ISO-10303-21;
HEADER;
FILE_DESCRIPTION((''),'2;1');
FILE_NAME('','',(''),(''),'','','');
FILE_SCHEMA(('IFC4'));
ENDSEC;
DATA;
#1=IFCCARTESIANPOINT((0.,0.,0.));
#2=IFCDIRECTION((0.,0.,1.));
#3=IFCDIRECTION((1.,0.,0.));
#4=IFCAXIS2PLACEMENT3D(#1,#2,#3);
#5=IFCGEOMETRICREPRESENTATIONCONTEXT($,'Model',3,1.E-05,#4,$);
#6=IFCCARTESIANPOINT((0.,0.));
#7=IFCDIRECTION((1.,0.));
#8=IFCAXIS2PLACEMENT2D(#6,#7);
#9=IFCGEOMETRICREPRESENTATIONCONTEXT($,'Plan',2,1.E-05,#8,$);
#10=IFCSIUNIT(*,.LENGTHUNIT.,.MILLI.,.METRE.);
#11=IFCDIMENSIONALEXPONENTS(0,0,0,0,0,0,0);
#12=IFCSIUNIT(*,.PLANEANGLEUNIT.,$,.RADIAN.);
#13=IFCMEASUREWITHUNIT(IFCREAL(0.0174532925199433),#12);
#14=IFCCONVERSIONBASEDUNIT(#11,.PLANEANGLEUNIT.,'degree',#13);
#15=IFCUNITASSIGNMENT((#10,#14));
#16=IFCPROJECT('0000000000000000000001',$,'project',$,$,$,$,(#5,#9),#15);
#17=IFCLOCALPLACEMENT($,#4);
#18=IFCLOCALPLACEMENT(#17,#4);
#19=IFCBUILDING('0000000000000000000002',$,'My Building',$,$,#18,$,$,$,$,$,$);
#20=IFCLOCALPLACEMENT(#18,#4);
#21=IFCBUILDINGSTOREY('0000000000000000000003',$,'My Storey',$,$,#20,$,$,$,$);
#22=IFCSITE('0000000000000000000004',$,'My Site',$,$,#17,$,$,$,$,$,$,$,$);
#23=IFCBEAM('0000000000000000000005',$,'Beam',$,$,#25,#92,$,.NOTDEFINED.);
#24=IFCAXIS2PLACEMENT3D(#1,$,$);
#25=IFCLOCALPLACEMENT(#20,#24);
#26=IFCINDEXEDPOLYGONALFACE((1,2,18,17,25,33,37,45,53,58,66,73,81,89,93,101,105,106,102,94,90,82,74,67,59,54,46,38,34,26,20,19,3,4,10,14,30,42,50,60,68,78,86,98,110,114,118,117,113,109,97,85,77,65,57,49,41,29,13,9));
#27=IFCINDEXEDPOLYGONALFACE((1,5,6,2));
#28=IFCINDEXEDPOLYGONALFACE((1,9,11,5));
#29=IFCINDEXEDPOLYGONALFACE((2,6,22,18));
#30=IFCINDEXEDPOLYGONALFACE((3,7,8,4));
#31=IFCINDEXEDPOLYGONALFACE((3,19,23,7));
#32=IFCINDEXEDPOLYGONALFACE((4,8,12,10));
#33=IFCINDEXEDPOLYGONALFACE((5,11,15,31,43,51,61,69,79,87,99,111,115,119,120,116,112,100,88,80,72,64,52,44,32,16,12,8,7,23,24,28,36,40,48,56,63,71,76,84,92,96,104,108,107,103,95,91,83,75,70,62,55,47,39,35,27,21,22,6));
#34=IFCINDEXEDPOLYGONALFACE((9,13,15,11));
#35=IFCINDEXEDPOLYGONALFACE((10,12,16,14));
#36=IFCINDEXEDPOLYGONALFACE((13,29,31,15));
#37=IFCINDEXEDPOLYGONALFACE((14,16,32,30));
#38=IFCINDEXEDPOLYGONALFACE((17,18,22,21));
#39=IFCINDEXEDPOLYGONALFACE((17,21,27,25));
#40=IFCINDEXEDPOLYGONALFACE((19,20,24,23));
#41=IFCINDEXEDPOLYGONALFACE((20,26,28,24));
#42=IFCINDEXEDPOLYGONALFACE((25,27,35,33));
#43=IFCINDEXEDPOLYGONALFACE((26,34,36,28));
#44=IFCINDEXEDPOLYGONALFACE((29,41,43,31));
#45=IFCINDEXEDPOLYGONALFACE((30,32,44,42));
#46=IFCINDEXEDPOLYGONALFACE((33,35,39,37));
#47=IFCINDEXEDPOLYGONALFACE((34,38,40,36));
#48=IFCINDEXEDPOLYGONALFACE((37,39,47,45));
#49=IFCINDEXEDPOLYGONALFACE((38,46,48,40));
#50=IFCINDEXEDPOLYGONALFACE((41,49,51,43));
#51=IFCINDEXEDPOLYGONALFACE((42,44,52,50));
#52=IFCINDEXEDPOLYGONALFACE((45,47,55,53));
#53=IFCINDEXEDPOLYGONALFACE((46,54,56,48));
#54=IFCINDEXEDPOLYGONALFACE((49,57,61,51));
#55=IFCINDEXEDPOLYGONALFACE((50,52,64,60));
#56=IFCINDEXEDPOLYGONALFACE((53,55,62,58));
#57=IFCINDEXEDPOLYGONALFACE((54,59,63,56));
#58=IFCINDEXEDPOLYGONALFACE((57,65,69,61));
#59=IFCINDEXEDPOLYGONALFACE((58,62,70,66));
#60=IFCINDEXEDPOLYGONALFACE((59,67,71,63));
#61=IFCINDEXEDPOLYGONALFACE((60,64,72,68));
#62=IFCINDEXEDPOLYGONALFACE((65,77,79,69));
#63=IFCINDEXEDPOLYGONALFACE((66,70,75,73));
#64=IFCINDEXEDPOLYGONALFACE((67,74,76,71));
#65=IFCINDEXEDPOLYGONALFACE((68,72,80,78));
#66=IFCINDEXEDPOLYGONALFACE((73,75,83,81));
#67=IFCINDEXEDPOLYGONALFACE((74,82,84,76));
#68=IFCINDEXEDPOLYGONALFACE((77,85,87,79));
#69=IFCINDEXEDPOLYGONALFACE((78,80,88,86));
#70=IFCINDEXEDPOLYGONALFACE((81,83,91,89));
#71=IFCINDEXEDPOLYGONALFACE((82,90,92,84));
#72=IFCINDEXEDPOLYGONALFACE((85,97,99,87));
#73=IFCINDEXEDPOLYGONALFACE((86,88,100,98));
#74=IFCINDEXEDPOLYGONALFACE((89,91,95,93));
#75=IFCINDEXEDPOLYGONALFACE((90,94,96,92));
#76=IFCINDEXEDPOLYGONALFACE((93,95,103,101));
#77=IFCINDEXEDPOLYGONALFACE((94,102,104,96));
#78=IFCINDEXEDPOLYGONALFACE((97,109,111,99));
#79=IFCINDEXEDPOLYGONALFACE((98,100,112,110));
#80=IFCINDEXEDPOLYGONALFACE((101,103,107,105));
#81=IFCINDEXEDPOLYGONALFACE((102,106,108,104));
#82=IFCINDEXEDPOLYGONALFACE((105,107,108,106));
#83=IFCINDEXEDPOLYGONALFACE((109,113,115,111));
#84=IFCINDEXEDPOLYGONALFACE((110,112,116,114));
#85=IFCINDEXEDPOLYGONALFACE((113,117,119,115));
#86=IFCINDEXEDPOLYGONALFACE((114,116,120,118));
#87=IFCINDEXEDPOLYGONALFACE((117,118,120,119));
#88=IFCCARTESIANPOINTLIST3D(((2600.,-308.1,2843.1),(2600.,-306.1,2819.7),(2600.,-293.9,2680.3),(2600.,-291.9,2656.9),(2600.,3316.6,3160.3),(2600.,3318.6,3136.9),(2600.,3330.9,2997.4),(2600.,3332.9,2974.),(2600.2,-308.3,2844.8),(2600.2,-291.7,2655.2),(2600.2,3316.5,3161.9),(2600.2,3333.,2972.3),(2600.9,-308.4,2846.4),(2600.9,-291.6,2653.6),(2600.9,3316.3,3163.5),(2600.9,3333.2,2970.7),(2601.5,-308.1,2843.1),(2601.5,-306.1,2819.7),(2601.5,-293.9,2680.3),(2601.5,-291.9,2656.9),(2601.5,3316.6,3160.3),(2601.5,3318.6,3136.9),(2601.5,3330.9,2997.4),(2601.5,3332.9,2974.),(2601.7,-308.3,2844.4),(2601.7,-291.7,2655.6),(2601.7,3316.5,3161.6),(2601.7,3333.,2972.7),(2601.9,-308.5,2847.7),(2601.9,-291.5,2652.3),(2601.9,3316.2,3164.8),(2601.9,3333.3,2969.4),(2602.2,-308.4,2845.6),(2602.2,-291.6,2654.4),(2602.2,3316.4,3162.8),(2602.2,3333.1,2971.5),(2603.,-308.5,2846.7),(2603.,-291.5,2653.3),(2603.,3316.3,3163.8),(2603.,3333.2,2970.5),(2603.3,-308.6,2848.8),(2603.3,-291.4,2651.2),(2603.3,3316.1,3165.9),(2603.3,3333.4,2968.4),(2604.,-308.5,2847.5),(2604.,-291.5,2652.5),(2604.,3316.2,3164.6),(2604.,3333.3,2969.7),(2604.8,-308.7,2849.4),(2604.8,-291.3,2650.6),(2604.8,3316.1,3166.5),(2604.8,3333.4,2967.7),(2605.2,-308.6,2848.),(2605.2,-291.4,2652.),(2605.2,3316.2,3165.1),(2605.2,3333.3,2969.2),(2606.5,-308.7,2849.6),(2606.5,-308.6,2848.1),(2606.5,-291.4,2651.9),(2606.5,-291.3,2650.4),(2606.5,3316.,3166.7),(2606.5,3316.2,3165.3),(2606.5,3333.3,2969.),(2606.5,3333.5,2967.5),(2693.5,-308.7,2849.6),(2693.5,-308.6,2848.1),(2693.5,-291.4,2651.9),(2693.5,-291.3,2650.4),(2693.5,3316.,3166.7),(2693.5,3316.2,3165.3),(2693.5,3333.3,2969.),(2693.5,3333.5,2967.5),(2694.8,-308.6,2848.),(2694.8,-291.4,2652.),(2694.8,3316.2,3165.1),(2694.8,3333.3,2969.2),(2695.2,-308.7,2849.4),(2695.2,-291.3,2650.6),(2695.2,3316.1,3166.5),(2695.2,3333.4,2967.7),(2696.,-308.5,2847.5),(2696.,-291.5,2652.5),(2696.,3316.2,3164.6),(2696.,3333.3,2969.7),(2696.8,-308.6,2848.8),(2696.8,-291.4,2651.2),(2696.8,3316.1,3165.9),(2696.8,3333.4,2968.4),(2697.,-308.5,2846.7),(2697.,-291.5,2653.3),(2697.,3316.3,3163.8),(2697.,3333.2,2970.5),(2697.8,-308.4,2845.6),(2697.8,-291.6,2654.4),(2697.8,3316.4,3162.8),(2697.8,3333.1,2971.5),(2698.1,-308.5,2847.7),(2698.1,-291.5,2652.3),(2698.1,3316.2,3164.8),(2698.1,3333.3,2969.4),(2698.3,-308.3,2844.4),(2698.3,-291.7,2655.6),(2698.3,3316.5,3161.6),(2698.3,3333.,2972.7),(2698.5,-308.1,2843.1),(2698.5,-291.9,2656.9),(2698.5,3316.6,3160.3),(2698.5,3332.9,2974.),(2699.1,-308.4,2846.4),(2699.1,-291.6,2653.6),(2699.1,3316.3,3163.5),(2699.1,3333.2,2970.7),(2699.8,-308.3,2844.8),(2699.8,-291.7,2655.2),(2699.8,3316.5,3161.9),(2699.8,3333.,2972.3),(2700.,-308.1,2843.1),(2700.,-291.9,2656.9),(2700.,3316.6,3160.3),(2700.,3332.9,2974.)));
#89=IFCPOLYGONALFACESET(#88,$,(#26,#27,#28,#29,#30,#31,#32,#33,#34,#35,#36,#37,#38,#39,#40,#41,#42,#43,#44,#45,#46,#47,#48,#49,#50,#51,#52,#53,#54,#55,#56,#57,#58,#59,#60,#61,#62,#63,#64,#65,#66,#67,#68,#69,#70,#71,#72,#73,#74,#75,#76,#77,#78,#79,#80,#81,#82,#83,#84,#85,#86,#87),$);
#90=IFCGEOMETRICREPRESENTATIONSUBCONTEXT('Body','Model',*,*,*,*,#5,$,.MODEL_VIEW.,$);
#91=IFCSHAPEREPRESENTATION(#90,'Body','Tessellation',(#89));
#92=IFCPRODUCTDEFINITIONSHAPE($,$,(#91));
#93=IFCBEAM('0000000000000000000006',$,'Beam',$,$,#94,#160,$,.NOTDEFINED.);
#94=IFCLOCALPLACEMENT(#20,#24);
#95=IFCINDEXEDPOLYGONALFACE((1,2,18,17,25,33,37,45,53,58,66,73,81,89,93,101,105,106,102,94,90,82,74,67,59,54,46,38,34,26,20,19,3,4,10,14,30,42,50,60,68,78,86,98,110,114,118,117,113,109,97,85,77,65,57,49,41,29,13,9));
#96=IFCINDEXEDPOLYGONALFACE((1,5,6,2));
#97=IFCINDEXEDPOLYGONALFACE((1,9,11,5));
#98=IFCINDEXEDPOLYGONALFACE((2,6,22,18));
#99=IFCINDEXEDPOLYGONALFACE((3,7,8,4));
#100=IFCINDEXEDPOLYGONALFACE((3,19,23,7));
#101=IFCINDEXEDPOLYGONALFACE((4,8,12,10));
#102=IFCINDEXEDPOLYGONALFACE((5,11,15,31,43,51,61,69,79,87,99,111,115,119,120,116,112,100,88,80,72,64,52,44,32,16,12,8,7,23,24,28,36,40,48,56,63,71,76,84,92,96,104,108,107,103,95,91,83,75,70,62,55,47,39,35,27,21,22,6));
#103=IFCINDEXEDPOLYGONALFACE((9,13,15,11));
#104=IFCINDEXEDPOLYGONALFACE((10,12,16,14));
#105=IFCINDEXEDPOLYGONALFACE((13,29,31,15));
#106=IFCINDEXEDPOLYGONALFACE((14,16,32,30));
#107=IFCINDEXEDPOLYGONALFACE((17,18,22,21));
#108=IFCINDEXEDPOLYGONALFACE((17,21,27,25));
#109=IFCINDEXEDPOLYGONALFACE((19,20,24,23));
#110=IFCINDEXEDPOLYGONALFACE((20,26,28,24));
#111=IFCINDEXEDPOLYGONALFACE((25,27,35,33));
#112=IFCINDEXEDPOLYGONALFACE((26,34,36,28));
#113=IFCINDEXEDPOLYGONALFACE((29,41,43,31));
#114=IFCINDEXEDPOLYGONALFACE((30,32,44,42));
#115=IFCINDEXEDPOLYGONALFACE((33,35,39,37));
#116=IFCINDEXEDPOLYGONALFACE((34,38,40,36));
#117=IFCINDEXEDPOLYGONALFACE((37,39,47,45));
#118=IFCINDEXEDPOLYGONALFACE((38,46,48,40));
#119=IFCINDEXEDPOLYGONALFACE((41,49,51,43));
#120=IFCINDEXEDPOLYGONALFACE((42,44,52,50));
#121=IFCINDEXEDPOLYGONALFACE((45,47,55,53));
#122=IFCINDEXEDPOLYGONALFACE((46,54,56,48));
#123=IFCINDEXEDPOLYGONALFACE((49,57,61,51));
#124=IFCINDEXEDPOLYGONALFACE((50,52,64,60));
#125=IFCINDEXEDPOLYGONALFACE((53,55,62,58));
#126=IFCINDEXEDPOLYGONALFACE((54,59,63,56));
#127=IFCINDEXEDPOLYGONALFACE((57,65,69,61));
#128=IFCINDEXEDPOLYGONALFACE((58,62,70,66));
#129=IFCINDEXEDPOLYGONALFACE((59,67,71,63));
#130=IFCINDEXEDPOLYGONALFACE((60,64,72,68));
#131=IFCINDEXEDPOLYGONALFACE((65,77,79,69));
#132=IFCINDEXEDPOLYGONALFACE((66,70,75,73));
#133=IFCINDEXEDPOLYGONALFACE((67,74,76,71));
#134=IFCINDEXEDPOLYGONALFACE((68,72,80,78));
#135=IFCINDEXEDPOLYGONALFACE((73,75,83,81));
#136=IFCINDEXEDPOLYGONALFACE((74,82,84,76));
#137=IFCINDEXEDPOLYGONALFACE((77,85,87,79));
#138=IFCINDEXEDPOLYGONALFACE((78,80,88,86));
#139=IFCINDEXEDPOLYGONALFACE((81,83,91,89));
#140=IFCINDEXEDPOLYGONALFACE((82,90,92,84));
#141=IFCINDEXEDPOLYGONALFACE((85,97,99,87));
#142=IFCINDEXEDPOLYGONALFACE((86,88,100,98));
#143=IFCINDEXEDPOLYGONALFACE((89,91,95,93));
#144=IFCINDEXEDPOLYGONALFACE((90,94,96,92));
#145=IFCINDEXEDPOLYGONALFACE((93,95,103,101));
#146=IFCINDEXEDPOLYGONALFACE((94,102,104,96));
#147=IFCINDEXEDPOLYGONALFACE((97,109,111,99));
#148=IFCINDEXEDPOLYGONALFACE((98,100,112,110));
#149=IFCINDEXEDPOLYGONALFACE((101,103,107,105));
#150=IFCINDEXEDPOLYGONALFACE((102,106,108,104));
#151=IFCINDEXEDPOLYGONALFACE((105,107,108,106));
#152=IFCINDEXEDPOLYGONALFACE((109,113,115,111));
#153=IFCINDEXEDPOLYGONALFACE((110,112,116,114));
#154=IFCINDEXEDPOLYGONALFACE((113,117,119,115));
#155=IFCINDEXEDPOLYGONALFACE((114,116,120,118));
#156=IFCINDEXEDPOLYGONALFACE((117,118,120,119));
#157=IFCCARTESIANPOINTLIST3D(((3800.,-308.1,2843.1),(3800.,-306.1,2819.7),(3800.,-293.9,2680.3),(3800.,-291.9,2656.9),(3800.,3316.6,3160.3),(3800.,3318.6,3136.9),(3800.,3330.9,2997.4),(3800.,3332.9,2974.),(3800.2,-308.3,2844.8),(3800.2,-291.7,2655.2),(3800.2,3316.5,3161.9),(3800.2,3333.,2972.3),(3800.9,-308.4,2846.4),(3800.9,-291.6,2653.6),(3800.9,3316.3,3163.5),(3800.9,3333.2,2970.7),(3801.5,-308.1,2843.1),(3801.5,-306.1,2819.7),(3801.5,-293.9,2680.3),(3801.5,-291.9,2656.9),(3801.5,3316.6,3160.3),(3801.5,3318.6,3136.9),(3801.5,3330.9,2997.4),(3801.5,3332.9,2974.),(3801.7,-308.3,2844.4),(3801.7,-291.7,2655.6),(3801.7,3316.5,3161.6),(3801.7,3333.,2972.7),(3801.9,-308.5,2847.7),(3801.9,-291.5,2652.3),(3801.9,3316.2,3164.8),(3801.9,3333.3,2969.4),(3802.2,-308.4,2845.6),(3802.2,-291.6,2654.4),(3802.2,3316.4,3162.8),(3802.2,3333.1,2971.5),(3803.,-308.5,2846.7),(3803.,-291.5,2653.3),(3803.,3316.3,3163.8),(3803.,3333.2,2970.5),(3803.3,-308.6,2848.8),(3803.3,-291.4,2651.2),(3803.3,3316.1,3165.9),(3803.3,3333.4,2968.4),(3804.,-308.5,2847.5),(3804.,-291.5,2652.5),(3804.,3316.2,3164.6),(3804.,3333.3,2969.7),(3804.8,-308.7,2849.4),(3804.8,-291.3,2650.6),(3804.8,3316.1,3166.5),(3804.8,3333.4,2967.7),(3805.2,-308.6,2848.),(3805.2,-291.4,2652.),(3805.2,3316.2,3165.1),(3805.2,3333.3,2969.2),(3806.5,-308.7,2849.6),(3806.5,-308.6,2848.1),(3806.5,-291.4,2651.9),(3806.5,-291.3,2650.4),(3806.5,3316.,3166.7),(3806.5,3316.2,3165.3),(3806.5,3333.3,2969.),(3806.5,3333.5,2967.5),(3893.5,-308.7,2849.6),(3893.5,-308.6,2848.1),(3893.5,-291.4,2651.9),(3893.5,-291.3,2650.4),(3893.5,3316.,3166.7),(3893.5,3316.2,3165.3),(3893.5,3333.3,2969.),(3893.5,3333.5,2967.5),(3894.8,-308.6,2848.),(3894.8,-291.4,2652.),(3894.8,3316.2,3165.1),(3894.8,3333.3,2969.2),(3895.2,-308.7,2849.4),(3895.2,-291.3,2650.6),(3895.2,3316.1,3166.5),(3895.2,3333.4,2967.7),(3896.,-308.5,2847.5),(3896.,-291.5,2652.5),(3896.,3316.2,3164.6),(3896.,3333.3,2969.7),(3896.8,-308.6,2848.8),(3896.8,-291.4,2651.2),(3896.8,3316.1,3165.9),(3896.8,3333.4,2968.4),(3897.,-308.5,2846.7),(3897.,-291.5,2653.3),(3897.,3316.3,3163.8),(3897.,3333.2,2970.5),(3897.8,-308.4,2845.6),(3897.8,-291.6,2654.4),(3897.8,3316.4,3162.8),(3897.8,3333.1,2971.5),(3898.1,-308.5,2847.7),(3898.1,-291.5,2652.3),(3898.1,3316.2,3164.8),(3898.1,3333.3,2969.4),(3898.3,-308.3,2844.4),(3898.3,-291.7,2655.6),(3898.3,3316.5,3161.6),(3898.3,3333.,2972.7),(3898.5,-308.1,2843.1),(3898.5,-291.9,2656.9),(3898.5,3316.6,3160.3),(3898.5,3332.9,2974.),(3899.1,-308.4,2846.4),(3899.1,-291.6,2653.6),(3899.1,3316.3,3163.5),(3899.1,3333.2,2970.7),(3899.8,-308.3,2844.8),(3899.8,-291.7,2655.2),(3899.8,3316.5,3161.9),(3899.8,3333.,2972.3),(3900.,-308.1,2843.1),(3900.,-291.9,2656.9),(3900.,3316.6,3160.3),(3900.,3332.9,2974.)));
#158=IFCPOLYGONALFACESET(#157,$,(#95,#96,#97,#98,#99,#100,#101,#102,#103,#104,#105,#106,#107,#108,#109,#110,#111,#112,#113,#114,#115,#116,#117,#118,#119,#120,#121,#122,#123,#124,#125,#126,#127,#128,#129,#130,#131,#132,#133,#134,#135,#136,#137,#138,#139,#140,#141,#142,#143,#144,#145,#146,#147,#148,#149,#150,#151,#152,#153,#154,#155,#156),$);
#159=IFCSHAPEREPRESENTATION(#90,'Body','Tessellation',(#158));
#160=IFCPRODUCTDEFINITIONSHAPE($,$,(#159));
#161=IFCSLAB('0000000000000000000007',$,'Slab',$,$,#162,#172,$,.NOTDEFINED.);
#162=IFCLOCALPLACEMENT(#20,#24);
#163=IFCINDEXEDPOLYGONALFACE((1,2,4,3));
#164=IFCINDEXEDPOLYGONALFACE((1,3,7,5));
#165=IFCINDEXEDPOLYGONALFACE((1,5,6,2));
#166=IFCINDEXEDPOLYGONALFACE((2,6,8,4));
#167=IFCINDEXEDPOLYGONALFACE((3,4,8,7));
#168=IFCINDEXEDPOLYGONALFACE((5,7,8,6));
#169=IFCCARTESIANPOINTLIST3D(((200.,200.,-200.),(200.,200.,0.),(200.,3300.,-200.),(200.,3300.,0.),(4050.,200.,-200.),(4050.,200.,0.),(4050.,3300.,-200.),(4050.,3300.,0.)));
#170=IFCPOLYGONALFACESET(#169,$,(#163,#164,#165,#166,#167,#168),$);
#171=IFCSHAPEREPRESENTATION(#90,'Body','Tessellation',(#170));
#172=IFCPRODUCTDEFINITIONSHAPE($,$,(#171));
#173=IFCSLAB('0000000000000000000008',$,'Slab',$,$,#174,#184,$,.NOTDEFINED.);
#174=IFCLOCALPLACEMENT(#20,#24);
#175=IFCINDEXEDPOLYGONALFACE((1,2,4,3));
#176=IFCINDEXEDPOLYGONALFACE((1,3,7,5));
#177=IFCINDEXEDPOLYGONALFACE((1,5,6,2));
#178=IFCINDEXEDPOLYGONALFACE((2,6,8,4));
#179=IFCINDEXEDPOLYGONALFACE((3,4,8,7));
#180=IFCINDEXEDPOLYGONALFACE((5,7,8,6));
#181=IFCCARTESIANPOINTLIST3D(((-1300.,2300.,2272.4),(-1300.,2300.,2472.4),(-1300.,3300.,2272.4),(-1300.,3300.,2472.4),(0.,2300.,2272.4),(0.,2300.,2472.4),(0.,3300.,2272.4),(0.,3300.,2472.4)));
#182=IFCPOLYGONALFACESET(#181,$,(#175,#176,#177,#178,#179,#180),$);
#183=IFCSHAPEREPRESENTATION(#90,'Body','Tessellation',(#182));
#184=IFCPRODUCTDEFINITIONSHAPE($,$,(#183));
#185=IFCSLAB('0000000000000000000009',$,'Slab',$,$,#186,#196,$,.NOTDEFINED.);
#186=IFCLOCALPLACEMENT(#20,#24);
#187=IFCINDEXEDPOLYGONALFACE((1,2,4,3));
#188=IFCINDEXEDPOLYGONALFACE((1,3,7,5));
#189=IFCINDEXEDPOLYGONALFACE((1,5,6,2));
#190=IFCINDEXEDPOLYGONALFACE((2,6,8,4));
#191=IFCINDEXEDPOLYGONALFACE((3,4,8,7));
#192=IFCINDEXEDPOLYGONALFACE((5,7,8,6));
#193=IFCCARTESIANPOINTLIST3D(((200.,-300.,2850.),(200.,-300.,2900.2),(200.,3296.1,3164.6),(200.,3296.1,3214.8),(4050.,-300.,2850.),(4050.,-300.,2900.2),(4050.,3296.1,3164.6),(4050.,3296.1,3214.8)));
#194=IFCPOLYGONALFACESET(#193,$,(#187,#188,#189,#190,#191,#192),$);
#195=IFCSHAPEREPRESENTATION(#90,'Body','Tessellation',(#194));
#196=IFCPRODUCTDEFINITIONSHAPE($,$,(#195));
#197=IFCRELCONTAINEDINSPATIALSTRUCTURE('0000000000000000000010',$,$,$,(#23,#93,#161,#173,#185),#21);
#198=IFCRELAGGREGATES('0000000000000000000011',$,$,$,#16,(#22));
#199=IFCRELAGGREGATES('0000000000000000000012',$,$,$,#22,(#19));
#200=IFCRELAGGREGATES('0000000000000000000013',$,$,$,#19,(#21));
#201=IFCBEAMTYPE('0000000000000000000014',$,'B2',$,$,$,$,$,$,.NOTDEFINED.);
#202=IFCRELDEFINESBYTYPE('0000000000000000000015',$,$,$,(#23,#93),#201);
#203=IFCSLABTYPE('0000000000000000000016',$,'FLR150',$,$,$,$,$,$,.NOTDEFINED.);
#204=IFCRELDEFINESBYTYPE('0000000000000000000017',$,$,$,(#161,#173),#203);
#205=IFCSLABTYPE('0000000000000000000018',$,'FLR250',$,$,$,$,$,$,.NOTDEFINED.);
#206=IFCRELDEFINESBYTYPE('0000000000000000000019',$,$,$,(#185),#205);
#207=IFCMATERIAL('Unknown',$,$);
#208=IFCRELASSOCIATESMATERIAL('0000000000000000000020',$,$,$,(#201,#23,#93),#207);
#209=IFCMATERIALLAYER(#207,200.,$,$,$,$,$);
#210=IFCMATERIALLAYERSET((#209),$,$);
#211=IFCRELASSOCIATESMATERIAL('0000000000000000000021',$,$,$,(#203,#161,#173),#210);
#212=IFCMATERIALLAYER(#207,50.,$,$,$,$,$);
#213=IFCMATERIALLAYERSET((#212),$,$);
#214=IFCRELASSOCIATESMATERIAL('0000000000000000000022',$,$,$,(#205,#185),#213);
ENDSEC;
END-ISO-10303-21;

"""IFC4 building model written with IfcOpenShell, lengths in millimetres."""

from ifc_helpers import new_model, entity, si_unit, converted_unit, frame, origin_with_axes, origin_2d_with_axis, place, context, subcontext, project, spatial, line, indexed_curve, c_section, outline, extrude, material, layer, layer_set, layer_usage, material_profile, profile_set, profile_usage, type_object, element, save


model = new_model("IFC4")

# Units and contexts
model_context = context("Model", 3, precision=1e-05, world=origin_with_axes())
plan_context = context("Plan", 2, precision=1e-05, world=origin_2d_with_axis())
body_context = subcontext(model_context, "Body", "Model", "MODEL_VIEW")
ifc_project = project(units=[si_unit("LENGTHUNIT", "METRE", prefix="MILLI"), converted_unit("PLANEANGLEUNIT", "degree", entity("IfcReal", 0.0174532925199433), si_unit("PLANEANGLEUNIT", "RADIAN"), dimensions=[0, 0, 0, 0, 0, 0, 0])], contexts=[model_context, plan_context])

# Site, building, storey
site_placement = place(None, origin_with_axes())
site = spatial("IfcSite", under=ifc_project, at=site_placement, Name="My Site")
building_placement = place(site_placement, origin_with_axes())
building = spatial("IfcBuilding", under=site, at=building_placement, Name="My Building")
storey_placement = place(building_placement, origin_with_axes())
storey = spatial("IfcBuildingStorey", under=building, at=storey_placement, Name="My Storey")

# Shared definitions
ifc_material = material(Name="Unknown")

# Beams
ifc_material_profile_1 = material_profile(ifc_material, c_section(Depth=200.0, Width=100.0, WallThickness=1.5, Girth=30.0, InternalFilletRadius=5.0))
ifc_profile_set_1 = profile_set([ifc_material_profile_1])
beam_type_1 = type_object("IfcBeamType", Name="B2", PredefinedType="NOTDEFINED", material=ifc_profile_set_1)
ifc_profile_usage_1 = profile_usage(ifc_profile_set_1, cardinal=5)
beam_1_placement = place(storey_placement, frame((2650.0, -300.0, 2750.0), z_axis=(0.0, 0.996195, 0.087156), x_axis=(-1.0, 0.0, 0.0)))
element("IfcBeam", 1, at=beam_1_placement, inside=storey, type_object=beam_type_1, material=ifc_profile_usage_1, Name="Beam", PredefinedType="NOTDEFINED", context=body_context, shape_type="SweptSolid", body=[
    extrude(c_section(Depth=200.0, Width=100.0, WallThickness=1.5, Girth=30.0, InternalFilletRadius=5.0), origin_with_axes(), (0.0, 0.0, 1.0), 3638.6),
])
ifc_profile_usage_2 = profile_usage(ifc_profile_set_1, cardinal=5)
beam_2_placement = place(storey_placement, frame((3850.0, -300.0, 2750.0), z_axis=(0.0, 0.996195, 0.087156), x_axis=(-1.0, 0.0, 0.0)))
element("IfcBeam", 2, at=beam_2_placement, inside=storey, type_object=beam_type_1, material=ifc_profile_usage_2, Name="Beam", PredefinedType="NOTDEFINED", context=body_context, shape_type="SweptSolid", body=[
    extrude(c_section(Depth=200.0, Width=100.0, WallThickness=1.5, Girth=30.0, InternalFilletRadius=5.0), origin_with_axes(), (0.0, 0.0, 1.0), 3638.6),
])

# Slabs
ifc_layer_1 = layer(ifc_material, 200.0)
ifc_layer_set_1 = layer_set([ifc_layer_1])
ifc_layer_usage_1 = layer_usage(ifc_layer_set_1, "AXIS3", "POSITIVE", 0.0)
slab_type_1 = type_object("IfcSlabType", Name="FLR150", PredefinedType="NOTDEFINED", material=ifc_layer_set_1)
slab_1_placement = place(storey_placement, frame((200.0, 200.0, -200.0), z_axis=(0.0, 0.0, 1.0), x_axis=(1.0, 0.0, 0.0)))
element("IfcSlab", 3, at=slab_1_placement, inside=storey, type_object=slab_type_1, material=ifc_layer_usage_1, Name="Slab", PredefinedType="NOTDEFINED", context=body_context, shape_type="SweptSolid", body=[
    extrude(outline(indexed_curve([(0.0, 0.0), (3850.0, 0.0), (3850.0, 3100.0), (0.0, 3100.0)], segments=[line(3, 2), line(2, 1), line(1, 4), line(4, 3)], self_intersect=False)), None, (0.0, 0.0, 1.0), 200.0),
])
ifc_layer_usage_2 = layer_usage(ifc_layer_set_1, "AXIS3", "POSITIVE", 0.0)
slab_2_placement = place(storey_placement, frame((-1300.0, 2300.0, 2272.4), z_axis=(0.0, 0.0, 1.0), x_axis=(1.0, 0.0, 0.0)))
element("IfcSlab", 4, at=slab_2_placement, inside=storey, type_object=slab_type_1, material=ifc_layer_usage_2, Name="Slab", PredefinedType="NOTDEFINED", context=body_context, shape_type="SweptSolid", body=[
    extrude(outline(indexed_curve([(0.0, 0.0), (1300.0, 0.0), (1300.0, 1000.0), (0.0, 1000.0)], segments=[line(4, 1), line(1, 2), line(2, 3), line(3, 4)], self_intersect=False)), None, (0.0, 0.0, 1.0), 200.0),
])
ifc_layer_2 = layer(ifc_material, 50.0)
ifc_layer_set_2 = layer_set([ifc_layer_2])
ifc_layer_usage_3 = layer_usage(ifc_layer_set_2, "AXIS3", "POSITIVE", 0.0)
slab_type_2 = type_object("IfcSlabType", Name="FLR250", PredefinedType="NOTDEFINED", material=ifc_layer_set_2)
slab_3_placement = place(storey_placement, frame((200.0, -300.0, 2850.0), z_axis=(0.0, -0.087156, 0.996195), x_axis=(1.0, 0.0, 0.0)))
element("IfcSlab", 5, at=slab_3_placement, inside=storey, type_object=slab_type_2, material=ifc_layer_usage_3, Name="Slab", PredefinedType="NOTDEFINED", context=body_context, shape_type="SweptSolid", body=[
    extrude(outline(indexed_curve([(0.0, 3609.8), (0.0, 0.0), (3850.0, 0.0), (3850.0, 3609.8)], segments=[line(4, 1), line(1, 2), line(2, 3), line(3, 4)], self_intersect=False)), None, (0.0, 0.087156, 0.996195), 50.2),
])

save(model, "model.ifc")
